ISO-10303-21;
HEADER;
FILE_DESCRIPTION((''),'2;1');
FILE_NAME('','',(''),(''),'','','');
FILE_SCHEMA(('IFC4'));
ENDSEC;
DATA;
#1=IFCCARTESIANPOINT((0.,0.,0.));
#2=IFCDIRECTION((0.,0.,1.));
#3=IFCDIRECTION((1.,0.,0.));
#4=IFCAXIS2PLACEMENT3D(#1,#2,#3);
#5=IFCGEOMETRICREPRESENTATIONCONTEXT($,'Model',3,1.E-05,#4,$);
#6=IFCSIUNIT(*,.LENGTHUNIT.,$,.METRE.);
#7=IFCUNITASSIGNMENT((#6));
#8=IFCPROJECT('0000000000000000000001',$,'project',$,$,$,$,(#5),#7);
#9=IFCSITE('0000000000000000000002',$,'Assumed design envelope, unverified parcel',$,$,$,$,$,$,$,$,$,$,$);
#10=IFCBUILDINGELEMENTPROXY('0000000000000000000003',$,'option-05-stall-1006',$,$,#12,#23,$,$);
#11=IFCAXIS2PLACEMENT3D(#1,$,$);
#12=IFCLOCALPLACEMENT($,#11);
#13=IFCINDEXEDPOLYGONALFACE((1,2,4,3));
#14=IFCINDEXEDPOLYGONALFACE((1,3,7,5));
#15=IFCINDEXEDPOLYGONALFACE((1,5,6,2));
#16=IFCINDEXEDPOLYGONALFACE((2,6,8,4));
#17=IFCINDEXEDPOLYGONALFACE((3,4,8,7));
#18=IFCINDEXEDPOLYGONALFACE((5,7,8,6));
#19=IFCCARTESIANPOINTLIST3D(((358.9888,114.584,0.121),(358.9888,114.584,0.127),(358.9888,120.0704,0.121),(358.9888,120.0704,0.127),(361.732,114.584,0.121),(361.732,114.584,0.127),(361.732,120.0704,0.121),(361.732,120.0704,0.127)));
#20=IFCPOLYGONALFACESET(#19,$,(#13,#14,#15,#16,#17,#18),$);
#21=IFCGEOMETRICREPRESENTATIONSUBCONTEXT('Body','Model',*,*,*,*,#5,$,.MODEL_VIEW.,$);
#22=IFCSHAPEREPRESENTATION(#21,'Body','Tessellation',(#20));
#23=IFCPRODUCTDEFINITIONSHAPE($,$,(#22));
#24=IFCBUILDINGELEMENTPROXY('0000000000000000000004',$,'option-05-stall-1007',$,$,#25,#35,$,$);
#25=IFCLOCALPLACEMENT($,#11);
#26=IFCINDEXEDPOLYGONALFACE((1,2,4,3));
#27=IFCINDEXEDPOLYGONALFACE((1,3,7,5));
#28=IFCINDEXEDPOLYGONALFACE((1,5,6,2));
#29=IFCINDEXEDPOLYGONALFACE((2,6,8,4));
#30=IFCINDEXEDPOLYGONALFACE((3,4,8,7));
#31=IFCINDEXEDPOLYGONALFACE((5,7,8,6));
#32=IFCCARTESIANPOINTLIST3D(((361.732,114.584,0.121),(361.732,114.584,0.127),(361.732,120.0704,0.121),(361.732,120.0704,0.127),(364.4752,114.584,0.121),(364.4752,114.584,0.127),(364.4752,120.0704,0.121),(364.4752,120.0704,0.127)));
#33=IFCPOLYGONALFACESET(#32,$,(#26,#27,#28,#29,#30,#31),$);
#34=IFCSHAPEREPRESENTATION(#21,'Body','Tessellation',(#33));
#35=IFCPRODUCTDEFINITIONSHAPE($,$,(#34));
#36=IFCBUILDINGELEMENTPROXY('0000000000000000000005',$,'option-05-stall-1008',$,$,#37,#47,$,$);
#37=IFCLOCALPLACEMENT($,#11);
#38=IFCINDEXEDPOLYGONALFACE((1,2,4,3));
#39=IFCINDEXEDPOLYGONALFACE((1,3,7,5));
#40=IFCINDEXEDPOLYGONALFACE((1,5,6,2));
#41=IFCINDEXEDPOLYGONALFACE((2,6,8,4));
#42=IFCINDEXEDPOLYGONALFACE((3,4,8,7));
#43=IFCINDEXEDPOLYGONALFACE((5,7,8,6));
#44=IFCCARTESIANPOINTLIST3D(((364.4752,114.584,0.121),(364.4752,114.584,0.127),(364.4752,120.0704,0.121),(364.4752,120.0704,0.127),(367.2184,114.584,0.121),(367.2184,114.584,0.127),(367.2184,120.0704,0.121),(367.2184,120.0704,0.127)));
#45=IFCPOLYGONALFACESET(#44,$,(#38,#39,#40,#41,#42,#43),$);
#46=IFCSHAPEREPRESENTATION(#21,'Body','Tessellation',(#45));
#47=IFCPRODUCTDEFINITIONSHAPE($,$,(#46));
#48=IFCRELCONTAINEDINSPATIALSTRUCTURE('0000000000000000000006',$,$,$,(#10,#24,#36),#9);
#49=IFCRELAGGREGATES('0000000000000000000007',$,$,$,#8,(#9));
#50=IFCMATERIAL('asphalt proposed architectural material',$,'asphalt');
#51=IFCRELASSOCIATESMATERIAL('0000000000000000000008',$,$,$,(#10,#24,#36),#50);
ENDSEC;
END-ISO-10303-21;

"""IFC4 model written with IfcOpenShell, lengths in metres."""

from ifc_helpers import new_model, si_unit, frame, origin_with_axes, place, context, subcontext, project, spatial, rectangle, extrude, material, element, save


model = new_model("IFC4")

# Units and contexts
model_context = context("Model", 3, precision=1e-05, world=origin_with_axes())
body_context = subcontext(model_context, "Body", "Model", "MODEL_VIEW")
ifc_project = project(units=[si_unit("LENGTHUNIT", "METRE")], contexts=[model_context])

# Site
site = spatial("IfcSite", under=ifc_project, Name="Assumed design envelope, unverified parcel")

# Building element proxies
ifc_material = material(Name="asphalt proposed architectural material", Category="asphalt")
for number, where, z_axis, x_axis, name in (
    (1, (360.3604, 117.3272, 0.121), (0.0, 0.0, 1.0), (1.0, 0.0, 0.0), "option-05-stall-1006"),
    (2, (363.1036, 117.3272, 0.121), (0.0, 0.0, 1.0), (1.0, 0.0, 0.0), "option-05-stall-1007"),
    (3, (365.8468, 117.3272, 0.121), (0.0, 0.0, 1.0), (1.0, 0.0, 0.0), "option-05-stall-1008"),
):
    element("IfcBuildingElementProxy", number, at=place(None, frame(where, z_axis=z_axis, x_axis=x_axis)), inside=site, material=ifc_material, Name=name, context=body_context, shape_type="SweptSolid", body=[
        extrude(rectangle(XDim=2.7432, YDim=5.4864), origin_with_axes(), (0.0, 0.0, 1.0), 0.006),
    ])

save(model, "model.ifc")
